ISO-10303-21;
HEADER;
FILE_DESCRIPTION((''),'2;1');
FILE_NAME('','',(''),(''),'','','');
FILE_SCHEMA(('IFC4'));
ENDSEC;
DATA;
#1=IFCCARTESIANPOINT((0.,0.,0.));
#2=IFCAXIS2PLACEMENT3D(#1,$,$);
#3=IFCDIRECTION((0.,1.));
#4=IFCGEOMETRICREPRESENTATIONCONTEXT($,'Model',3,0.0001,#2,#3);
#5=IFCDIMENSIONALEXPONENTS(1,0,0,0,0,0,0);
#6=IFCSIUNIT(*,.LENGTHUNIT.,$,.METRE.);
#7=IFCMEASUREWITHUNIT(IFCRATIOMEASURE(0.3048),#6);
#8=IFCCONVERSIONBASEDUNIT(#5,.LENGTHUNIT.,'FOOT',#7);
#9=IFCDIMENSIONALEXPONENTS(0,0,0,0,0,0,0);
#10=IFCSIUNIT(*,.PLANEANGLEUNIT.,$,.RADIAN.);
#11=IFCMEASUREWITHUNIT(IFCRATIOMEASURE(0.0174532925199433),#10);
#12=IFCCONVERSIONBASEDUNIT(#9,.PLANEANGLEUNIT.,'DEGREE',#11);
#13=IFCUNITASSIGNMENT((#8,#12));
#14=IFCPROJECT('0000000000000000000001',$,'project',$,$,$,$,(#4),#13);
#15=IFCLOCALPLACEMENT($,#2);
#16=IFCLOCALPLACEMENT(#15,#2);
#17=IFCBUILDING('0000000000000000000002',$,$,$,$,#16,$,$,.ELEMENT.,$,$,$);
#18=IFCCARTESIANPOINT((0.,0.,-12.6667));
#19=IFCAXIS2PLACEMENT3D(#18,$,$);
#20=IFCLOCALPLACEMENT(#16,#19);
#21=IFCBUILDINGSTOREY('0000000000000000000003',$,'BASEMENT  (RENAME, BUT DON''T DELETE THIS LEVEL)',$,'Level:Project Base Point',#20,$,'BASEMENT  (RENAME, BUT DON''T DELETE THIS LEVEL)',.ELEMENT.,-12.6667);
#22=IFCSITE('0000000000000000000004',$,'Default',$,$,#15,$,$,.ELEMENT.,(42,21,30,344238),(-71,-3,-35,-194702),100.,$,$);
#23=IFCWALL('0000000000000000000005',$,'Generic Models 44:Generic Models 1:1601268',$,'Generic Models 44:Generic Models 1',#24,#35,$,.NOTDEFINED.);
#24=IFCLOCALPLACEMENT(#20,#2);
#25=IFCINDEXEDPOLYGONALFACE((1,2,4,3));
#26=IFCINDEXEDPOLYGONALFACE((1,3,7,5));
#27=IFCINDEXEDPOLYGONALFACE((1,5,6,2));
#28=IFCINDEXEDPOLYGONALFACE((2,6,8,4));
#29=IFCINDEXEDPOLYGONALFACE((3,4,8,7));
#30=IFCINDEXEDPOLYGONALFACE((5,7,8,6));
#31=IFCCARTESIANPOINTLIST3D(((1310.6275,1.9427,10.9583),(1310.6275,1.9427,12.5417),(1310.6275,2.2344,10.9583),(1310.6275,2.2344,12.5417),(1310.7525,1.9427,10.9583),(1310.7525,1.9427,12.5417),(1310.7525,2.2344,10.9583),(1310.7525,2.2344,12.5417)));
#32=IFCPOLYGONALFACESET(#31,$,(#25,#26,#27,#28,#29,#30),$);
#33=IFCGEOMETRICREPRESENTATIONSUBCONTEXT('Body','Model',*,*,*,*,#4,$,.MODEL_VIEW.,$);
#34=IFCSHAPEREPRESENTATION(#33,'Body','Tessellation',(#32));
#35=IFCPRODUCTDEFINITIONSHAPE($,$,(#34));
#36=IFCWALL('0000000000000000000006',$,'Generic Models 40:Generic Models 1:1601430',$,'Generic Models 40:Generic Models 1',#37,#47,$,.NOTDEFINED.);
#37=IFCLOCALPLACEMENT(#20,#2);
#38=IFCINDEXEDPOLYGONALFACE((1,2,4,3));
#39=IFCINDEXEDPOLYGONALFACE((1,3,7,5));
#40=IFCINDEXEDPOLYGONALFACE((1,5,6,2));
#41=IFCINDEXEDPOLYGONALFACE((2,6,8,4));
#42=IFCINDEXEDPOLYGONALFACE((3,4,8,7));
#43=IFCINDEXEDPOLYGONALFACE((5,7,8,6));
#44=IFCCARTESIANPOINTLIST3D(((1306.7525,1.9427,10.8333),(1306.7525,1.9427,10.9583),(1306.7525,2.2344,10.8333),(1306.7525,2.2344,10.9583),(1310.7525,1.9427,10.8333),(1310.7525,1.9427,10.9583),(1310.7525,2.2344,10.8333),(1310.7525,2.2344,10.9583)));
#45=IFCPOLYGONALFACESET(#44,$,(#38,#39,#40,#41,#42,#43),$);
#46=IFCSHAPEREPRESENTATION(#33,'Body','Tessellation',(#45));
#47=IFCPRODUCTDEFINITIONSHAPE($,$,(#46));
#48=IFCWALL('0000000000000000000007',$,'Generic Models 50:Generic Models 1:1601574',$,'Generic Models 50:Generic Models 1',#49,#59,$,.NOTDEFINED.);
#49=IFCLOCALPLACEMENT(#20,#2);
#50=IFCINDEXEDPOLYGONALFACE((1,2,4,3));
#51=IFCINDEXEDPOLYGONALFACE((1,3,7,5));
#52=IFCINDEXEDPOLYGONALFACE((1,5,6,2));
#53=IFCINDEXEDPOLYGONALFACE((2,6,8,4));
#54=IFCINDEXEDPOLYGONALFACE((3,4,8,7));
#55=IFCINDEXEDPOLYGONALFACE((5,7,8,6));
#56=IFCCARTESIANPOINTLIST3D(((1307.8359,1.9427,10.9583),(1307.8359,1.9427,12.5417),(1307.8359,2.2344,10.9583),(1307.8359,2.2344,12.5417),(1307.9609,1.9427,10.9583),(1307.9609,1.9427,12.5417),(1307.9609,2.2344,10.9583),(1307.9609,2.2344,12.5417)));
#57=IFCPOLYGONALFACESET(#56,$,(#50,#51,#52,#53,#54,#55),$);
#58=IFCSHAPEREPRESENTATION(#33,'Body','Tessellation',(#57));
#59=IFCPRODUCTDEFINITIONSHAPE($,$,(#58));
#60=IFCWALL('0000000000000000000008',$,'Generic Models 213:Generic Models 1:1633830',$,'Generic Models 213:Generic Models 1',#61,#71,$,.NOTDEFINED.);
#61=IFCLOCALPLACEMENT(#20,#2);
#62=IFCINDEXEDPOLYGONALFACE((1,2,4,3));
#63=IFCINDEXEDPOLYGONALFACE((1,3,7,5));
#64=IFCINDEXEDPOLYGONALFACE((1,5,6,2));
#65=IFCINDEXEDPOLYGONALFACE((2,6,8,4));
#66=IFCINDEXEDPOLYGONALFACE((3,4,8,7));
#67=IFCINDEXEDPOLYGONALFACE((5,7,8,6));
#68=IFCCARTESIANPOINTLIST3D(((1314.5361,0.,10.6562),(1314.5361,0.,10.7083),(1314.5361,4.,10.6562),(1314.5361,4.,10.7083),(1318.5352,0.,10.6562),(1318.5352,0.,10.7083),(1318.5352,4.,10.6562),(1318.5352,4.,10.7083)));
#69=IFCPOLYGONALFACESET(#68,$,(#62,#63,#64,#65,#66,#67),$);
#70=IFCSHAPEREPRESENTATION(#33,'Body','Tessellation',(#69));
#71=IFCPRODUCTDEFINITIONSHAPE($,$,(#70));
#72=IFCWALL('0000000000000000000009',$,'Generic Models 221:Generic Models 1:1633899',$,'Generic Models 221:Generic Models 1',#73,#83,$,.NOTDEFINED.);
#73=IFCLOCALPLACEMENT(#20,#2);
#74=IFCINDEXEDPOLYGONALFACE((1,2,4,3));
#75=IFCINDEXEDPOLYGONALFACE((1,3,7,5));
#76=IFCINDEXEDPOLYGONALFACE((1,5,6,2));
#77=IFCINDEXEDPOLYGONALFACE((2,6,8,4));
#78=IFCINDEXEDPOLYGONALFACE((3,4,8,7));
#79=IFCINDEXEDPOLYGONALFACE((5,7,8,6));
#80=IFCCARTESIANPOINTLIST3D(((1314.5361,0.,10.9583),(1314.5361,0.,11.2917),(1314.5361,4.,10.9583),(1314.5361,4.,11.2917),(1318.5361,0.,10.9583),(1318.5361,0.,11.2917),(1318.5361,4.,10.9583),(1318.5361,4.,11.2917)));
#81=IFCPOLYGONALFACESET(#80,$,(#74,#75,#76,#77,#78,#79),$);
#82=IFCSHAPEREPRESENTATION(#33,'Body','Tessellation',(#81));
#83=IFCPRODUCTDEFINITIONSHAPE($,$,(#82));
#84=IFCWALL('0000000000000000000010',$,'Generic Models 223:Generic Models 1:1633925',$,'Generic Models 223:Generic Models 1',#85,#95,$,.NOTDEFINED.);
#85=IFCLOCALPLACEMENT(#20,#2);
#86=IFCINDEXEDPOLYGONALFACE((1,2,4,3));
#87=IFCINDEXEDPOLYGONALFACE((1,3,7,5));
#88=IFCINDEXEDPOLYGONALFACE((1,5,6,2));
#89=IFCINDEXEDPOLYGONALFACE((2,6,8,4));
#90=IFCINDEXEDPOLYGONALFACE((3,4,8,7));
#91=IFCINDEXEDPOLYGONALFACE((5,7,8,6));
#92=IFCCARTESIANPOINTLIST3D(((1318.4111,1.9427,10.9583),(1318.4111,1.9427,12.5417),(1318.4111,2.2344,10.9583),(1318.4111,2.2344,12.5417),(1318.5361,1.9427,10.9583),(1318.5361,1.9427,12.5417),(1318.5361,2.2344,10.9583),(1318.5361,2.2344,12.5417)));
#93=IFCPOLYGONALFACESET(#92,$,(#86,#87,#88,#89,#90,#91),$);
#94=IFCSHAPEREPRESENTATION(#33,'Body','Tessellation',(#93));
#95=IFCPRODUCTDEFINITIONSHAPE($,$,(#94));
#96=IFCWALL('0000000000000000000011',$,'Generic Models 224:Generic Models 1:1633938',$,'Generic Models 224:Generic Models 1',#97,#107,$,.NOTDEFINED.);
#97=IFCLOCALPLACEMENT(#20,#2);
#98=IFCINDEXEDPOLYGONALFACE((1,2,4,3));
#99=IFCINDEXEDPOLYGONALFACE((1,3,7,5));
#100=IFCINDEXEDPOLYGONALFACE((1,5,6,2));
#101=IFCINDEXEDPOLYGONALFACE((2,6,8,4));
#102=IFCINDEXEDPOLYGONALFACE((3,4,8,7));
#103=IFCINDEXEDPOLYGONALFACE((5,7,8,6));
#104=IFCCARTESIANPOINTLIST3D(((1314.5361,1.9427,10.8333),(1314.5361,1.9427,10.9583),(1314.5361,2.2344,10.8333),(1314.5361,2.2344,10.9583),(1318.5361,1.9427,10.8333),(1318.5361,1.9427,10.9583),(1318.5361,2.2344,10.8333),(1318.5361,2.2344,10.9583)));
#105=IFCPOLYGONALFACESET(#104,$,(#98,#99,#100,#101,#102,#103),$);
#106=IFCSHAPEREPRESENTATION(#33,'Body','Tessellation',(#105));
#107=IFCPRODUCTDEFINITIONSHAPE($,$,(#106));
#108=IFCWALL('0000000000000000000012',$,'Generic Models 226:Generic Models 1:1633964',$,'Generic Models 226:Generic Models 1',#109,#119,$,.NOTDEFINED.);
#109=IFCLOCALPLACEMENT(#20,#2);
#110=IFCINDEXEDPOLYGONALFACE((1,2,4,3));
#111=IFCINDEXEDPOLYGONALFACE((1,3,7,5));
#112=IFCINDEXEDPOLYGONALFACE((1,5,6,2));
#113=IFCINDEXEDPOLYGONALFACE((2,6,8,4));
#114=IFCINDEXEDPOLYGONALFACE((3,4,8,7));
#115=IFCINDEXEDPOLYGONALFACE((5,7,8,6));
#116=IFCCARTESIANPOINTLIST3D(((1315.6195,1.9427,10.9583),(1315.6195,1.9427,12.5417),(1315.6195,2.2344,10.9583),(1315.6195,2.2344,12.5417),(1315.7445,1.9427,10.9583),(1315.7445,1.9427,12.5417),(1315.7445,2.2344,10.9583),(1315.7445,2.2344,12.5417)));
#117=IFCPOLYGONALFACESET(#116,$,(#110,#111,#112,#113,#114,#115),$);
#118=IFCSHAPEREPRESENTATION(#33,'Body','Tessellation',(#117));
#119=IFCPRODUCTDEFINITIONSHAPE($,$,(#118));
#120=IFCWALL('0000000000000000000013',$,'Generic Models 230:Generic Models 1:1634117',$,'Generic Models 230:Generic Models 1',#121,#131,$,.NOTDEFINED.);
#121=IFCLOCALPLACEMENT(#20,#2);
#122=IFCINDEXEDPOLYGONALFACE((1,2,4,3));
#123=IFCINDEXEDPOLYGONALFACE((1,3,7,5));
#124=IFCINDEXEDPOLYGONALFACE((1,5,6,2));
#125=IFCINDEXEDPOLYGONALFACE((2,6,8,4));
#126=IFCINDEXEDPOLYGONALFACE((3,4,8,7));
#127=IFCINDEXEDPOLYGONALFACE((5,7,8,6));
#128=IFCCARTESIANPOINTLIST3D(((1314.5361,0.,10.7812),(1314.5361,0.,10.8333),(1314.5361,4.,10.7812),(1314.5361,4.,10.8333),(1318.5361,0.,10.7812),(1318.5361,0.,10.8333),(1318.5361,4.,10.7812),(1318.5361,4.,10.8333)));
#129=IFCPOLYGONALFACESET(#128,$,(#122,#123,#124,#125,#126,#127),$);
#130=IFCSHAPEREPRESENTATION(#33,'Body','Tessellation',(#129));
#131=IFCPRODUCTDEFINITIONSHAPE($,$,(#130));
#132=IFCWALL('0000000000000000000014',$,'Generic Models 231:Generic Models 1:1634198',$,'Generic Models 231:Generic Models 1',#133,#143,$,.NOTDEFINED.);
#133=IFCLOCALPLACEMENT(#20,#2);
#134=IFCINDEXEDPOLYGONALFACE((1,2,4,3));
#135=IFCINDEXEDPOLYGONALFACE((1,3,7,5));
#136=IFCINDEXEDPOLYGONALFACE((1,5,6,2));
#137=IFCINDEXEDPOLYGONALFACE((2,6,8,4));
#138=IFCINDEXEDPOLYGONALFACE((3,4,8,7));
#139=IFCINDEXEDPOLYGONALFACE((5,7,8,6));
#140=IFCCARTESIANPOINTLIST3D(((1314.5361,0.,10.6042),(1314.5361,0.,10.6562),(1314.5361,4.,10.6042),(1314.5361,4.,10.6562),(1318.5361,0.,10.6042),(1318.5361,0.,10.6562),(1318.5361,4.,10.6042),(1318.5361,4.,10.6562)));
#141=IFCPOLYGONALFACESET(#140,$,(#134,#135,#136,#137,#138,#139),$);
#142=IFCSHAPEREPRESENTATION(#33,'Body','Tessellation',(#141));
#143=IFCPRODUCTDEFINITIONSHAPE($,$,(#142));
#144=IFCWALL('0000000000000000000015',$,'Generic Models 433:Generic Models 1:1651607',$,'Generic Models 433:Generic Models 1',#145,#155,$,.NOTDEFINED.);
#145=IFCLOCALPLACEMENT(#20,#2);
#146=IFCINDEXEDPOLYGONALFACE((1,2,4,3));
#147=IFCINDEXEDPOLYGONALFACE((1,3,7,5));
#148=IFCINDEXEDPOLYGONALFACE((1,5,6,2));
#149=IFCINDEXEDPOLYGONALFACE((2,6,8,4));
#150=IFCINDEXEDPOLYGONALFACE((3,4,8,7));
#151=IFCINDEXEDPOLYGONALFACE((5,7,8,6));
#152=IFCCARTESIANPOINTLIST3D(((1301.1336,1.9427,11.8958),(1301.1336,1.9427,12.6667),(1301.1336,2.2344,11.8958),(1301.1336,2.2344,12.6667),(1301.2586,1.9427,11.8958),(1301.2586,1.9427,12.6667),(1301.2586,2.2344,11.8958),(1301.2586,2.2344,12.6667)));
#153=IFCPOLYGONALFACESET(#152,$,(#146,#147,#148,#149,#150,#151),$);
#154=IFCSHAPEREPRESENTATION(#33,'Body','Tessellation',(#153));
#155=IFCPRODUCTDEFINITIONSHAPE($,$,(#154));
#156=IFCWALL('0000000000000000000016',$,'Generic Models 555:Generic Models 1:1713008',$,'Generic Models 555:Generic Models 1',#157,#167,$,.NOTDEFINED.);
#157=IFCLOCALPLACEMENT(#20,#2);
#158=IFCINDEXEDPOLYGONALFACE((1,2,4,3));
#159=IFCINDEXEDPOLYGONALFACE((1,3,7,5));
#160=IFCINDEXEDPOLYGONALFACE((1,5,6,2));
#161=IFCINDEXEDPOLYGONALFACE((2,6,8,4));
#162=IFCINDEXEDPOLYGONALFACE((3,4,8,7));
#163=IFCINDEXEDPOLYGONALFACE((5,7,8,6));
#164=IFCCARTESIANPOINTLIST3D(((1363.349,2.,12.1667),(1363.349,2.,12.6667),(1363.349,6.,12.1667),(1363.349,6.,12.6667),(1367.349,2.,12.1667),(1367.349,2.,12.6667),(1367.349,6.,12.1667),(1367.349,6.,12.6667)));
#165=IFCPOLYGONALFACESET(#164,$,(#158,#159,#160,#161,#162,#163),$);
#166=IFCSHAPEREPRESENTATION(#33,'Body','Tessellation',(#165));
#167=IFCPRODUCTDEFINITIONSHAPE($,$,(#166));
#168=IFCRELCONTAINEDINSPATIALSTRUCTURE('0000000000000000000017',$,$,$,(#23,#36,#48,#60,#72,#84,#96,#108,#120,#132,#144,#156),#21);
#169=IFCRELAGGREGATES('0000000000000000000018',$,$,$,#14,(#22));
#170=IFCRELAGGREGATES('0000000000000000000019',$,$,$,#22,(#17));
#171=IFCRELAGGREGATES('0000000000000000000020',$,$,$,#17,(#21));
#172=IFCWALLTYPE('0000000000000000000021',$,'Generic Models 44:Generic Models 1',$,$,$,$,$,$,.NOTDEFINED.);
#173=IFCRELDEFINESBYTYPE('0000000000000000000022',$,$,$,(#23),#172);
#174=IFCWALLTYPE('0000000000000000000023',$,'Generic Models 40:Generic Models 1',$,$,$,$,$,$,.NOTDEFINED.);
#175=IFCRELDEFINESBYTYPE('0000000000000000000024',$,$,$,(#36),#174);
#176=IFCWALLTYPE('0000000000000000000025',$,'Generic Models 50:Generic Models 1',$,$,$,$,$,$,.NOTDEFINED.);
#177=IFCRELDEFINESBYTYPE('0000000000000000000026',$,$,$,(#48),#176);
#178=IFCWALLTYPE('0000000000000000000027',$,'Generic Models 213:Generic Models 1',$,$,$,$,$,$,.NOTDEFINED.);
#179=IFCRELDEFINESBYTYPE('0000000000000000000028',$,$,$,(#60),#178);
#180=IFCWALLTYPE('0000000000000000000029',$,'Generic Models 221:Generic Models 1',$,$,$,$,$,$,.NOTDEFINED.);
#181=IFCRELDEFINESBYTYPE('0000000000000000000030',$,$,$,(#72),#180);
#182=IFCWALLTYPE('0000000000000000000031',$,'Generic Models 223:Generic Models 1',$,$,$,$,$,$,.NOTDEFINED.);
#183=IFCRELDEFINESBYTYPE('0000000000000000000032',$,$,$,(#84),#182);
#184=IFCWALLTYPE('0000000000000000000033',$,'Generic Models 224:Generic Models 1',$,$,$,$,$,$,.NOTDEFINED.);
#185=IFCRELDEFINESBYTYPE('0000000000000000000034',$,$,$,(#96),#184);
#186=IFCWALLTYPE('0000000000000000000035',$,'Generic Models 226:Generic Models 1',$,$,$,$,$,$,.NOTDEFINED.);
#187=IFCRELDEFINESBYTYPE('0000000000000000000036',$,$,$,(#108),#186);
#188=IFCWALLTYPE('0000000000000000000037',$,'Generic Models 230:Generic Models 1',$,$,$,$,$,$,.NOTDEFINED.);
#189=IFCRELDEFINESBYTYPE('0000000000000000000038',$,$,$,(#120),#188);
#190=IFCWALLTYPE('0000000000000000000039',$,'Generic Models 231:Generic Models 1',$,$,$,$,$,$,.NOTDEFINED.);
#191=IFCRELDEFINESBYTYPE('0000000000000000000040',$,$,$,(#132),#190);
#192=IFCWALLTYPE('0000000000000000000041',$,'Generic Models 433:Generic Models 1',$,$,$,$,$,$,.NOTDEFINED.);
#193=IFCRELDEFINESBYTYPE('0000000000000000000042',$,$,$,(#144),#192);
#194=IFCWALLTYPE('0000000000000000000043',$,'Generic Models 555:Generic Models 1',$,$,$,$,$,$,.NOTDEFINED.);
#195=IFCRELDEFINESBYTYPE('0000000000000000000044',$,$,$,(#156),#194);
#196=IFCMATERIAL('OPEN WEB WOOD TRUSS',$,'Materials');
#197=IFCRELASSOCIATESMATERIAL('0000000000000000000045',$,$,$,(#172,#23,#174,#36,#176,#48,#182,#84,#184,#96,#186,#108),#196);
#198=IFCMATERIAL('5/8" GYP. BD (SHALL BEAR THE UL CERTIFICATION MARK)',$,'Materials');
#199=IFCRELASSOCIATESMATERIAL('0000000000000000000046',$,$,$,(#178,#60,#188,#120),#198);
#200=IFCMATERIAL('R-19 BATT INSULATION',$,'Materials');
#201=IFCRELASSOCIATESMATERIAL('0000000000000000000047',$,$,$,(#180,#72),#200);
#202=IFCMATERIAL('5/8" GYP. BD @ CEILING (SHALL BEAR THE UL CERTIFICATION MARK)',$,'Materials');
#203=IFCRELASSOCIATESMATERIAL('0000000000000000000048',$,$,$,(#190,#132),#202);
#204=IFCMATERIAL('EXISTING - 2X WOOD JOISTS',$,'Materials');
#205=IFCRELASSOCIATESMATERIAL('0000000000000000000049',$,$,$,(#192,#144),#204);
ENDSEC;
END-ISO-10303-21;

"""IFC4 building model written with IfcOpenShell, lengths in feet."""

from ifc_helpers import new_model, entity, si_unit, converted_unit, direction, frame, frame_2d, origin, origin_2d_with_axis, place, context, subcontext, project, spatial, rectangle, extrude, material, type_object, element, save


model = new_model("IFC4")

# Units and contexts
model_context = context("Model", 3, precision=0.0001, world=origin(), true_north=direction((0.0, 1.0)))
body_context = subcontext(model_context, "Body", "Model", "MODEL_VIEW")
ifc_project = project(units=[converted_unit("LENGTHUNIT", "FOOT", entity("IfcRatioMeasure", 0.3048), si_unit("LENGTHUNIT", "METRE"), dimensions=[1, 0, 0, 0, 0, 0, 0]), converted_unit("PLANEANGLEUNIT", "DEGREE", entity("IfcRatioMeasure", 0.0174532925199433), si_unit("PLANEANGLEUNIT", "RADIAN"), dimensions=[0, 0, 0, 0, 0, 0, 0])], contexts=[model_context])

# Site, building, storey
site_placement = place(None, origin())
site = spatial("IfcSite", under=ifc_project, at=site_placement, Name="Default", CompositionType="ELEMENT", RefLatitude=(42, 21, 30, 344238), RefLongitude=(-71, -3, -35, -194702), RefElevation=100.0)
building_placement = place(site_placement, origin())
building = spatial("IfcBuilding", under=site, at=building_placement, CompositionType="ELEMENT")
storey_placement = place(building_placement, frame((0.0, 0.0, -12.6667)))
storey = spatial("IfcBuildingStorey", under=building, at=storey_placement, Name="BASEMENT  (RENAME, BUT DON'T DELETE THIS LEVEL)", ObjectType="Level:Project Base Point", LongName="BASEMENT  (RENAME, BUT DON'T DELETE THIS LEVEL)", CompositionType="ELEMENT", Elevation=-12.6667)

# Walls
ifc_material_1 = material(Name="OPEN WEB WOOD TRUSS", Category="Materials")
wall_type_1 = type_object("IfcWallType", Name="Generic Models 44:Generic Models 1", PredefinedType="NOTDEFINED", material=ifc_material_1)
wall_1_placement = place(storey_placement, frame((1310.6275, 1.9427, 10.9583), z_axis=(0.0, 0.0, 1.0), x_axis=(0.0, 1.0, 0.0)))
element("IfcWall", 1, at=wall_1_placement, inside=storey, type_object=wall_type_1, material=ifc_material_1, Name="Generic Models 44:Generic Models 1:1601268", ObjectType="Generic Models 44:Generic Models 1", PredefinedType="NOTDEFINED", context=body_context, shape_type="SweptSolid", body=[
    extrude(rectangle(XDim=0.2917, YDim=0.125, at=frame_2d((0.0, 0.0), x_axis=(1.0, 0.0))), frame((0.1458, -0.0625, 0.0)), (0.0, 0.0, 1.0), 1.5833),
])
wall_type_2 = type_object("IfcWallType", Name="Generic Models 40:Generic Models 1", PredefinedType="NOTDEFINED", material=ifc_material_1)
wall_2_placement = place(storey_placement, frame((1306.7525, 1.9427, 10.8333)))
element("IfcWall", 2, at=wall_2_placement, inside=storey, type_object=wall_type_2, material=ifc_material_1, Name="Generic Models 40:Generic Models 1:1601430", ObjectType="Generic Models 40:Generic Models 1", PredefinedType="NOTDEFINED", context=body_context, shape_type="SweptSolid", body=[
    extrude(rectangle(XDim=0.2917, YDim=4.0, at=frame_2d((0.0, 0.0), x_axis=(1.0, 0.0))), frame((2.0, 0.1458, 0.0), z_axis=(0.0, 0.0, 1.0), x_axis=(0.0, 1.0, 0.0)), (0.0, 0.0, 1.0), 0.125),
])
wall_type_3 = type_object("IfcWallType", Name="Generic Models 50:Generic Models 1", PredefinedType="NOTDEFINED", material=ifc_material_1)
wall_3_placement = place(storey_placement, frame((1307.8359, 1.9427, 10.9583), z_axis=(0.0, 0.0, 1.0), x_axis=(0.0, 1.0, 0.0)))
element("IfcWall", 3, at=wall_3_placement, inside=storey, type_object=wall_type_3, material=ifc_material_1, Name="Generic Models 50:Generic Models 1:1601574", ObjectType="Generic Models 50:Generic Models 1", PredefinedType="NOTDEFINED", context=body_context, shape_type="SweptSolid", body=[
    extrude(rectangle(XDim=0.2917, YDim=0.125, at=frame_2d((0.0, 0.0), x_axis=(1.0, 0.0))), frame((0.1458, -0.0625, 0.0)), (0.0, 0.0, 1.0), 1.5833),
])
ifc_material_2 = material(Name="5/8\" GYP. BD (SHALL BEAR THE UL CERTIFICATION MARK)", Category="Materials")
wall_type_4 = type_object("IfcWallType", Name="Generic Models 213:Generic Models 1", PredefinedType="NOTDEFINED", material=ifc_material_2)
wall_4_placement = place(storey_placement, frame((1314.5361, 0.0, 10.6562), z_axis=(0.0, 0.0, 1.0), x_axis=(0.0, 1.0, 0.0)))
element("IfcWall", 4, at=wall_4_placement, inside=storey, type_object=wall_type_4, material=ifc_material_2, Name="Generic Models 213:Generic Models 1:1633830", ObjectType="Generic Models 213:Generic Models 1", PredefinedType="NOTDEFINED", context=body_context, shape_type="SweptSolid", body=[
    extrude(rectangle(XDim=4.0, YDim=3.999, at=origin_2d_with_axis()), frame((2.0, -1.9995, 0.0)), (0.0, 0.0, 1.0), 0.0521),
])
ifc_material_3 = material(Name="R-19 BATT INSULATION", Category="Materials")
wall_type_5 = type_object("IfcWallType", Name="Generic Models 221:Generic Models 1", PredefinedType="NOTDEFINED", material=ifc_material_3)
wall_5_placement = place(storey_placement, frame((1314.5361, 0.0, 10.9583), z_axis=(0.0, 0.0, 1.0), x_axis=(0.0, 1.0, 0.0)))
element("IfcWall", 5, at=wall_5_placement, inside=storey, type_object=wall_type_5, material=ifc_material_3, Name="Generic Models 221:Generic Models 1:1633899", ObjectType="Generic Models 221:Generic Models 1", PredefinedType="NOTDEFINED", context=body_context, shape_type="SweptSolid", body=[
    extrude(rectangle(XDim=4.0, YDim=4.0, at=frame_2d((0.0, 0.0), x_axis=(1.0, 0.0))), frame((2.0, -2.0, 0.0)), (0.0, 0.0, 1.0), 0.3333),
])
wall_type_6 = type_object("IfcWallType", Name="Generic Models 223:Generic Models 1", PredefinedType="NOTDEFINED", material=ifc_material_1)
wall_6_placement = place(storey_placement, frame((1318.4111, 1.9427, 10.9583), z_axis=(0.0, 0.0, 1.0), x_axis=(0.0, 1.0, 0.0)))
element("IfcWall", 6, at=wall_6_placement, inside=storey, type_object=wall_type_6, material=ifc_material_1, Name="Generic Models 223:Generic Models 1:1633925", ObjectType="Generic Models 223:Generic Models 1", PredefinedType="NOTDEFINED", context=body_context, shape_type="SweptSolid", body=[
    extrude(rectangle(XDim=0.2917, YDim=0.125, at=frame_2d((0.0, 0.0), x_axis=(1.0, 0.0))), frame((0.1458, -0.0625, 0.0)), (0.0, 0.0, 1.0), 1.5833),
])
wall_type_7 = type_object("IfcWallType", Name="Generic Models 224:Generic Models 1", PredefinedType="NOTDEFINED", material=ifc_material_1)
wall_7_placement = place(storey_placement, frame((1314.5361, 1.9427, 10.8333)))
element("IfcWall", 7, at=wall_7_placement, inside=storey, type_object=wall_type_7, material=ifc_material_1, Name="Generic Models 224:Generic Models 1:1633938", ObjectType="Generic Models 224:Generic Models 1", PredefinedType="NOTDEFINED", context=body_context, shape_type="SweptSolid", body=[
    extrude(rectangle(XDim=0.2917, YDim=4.0, at=frame_2d((0.0, 0.0), x_axis=(1.0, 0.0))), frame((2.0, 0.1458, 0.0), z_axis=(0.0, 0.0, 1.0), x_axis=(0.0, 1.0, 0.0)), (0.0, 0.0, 1.0), 0.125),
])
wall_type_8 = type_object("IfcWallType", Name="Generic Models 226:Generic Models 1", PredefinedType="NOTDEFINED", material=ifc_material_1)
wall_8_placement = place(storey_placement, frame((1315.6195, 1.9427, 10.9583), z_axis=(0.0, 0.0, 1.0), x_axis=(0.0, 1.0, 0.0)))
element("IfcWall", 8, at=wall_8_placement, inside=storey, type_object=wall_type_8, material=ifc_material_1, Name="Generic Models 226:Generic Models 1:1633964", ObjectType="Generic Models 226:Generic Models 1", PredefinedType="NOTDEFINED", context=body_context, shape_type="SweptSolid", body=[
    extrude(rectangle(XDim=0.2917, YDim=0.125, at=frame_2d((0.0, 0.0), x_axis=(1.0, 0.0))), frame((0.1458, -0.0625, 0.0)), (0.0, 0.0, 1.0), 1.5833),
])
wall_type_9 = type_object("IfcWallType", Name="Generic Models 230:Generic Models 1", PredefinedType="NOTDEFINED", material=ifc_material_2)
wall_9_placement = place(storey_placement, frame((1314.5361, 0.0, 10.7812), z_axis=(0.0, 0.0, 1.0), x_axis=(0.0, 1.0, 0.0)))
element("IfcWall", 9, at=wall_9_placement, inside=storey, type_object=wall_type_9, material=ifc_material_2, Name="Generic Models 230:Generic Models 1:1634117", ObjectType="Generic Models 230:Generic Models 1", PredefinedType="NOTDEFINED", context=body_context, shape_type="SweptSolid", body=[
    extrude(rectangle(XDim=4.0, YDim=4.0, at=origin_2d_with_axis()), frame((2.0, -2.0, 0.0)), (0.0, 0.0, 1.0), 0.0521),
])
ifc_material_4 = material(Name="5/8\" GYP. BD @ CEILING (SHALL BEAR THE UL CERTIFICATION MARK)", Category="Materials")
wall_type_10 = type_object("IfcWallType", Name="Generic Models 231:Generic Models 1", PredefinedType="NOTDEFINED", material=ifc_material_4)
wall_10_placement = place(storey_placement, frame((1314.5361, 0.0, 10.6042), z_axis=(0.0, 0.0, 1.0), x_axis=(0.0, 1.0, 0.0)))
element("IfcWall", 10, at=wall_10_placement, inside=storey, type_object=wall_type_10, material=ifc_material_4, Name="Generic Models 231:Generic Models 1:1634198", ObjectType="Generic Models 231:Generic Models 1", PredefinedType="NOTDEFINED", context=body_context, shape_type="SweptSolid", body=[
    extrude(rectangle(XDim=4.0, YDim=4.0, at=origin_2d_with_axis()), frame((2.0, -2.0, 0.0)), (0.0, 0.0, 1.0), 0.0521),
])
ifc_material_5 = material(Name="EXISTING - 2X WOOD JOISTS", Category="Materials")
wall_type_11 = type_object("IfcWallType", Name="Generic Models 433:Generic Models 1", PredefinedType="NOTDEFINED", material=ifc_material_5)
wall_11_placement = place(storey_placement, frame((1301.1336, 1.9427, 11.8958), z_axis=(0.0, 0.0, 1.0), x_axis=(0.0, 1.0, 0.0)))
element("IfcWall", 11, at=wall_11_placement, inside=storey, type_object=wall_type_11, material=ifc_material_5, Name="Generic Models 433:Generic Models 1:1651607", ObjectType="Generic Models 433:Generic Models 1", PredefinedType="NOTDEFINED", context=body_context, shape_type="SweptSolid", body=[
    extrude(rectangle(XDim=0.2917, YDim=0.125, at=frame_2d((0.0, 0.0), x_axis=(1.0, 0.0))), frame((0.1458, -0.0625, 0.0)), (0.0, 0.0, 1.0), 0.7708),
])
wall_type_12 = type_object("IfcWallType", Name="Generic Models 555:Generic Models 1", PredefinedType="NOTDEFINED")
wall_12_placement = place(storey_placement, frame((1363.349, 2.0, 12.1667), z_axis=(0.0, 0.0, 1.0), x_axis=(0.0, 1.0, 0.0)))
element("IfcWall", 12, at=wall_12_placement, inside=storey, type_object=wall_type_12, Name="Generic Models 555:Generic Models 1:1713008", ObjectType="Generic Models 555:Generic Models 1", PredefinedType="NOTDEFINED", context=body_context, shape_type="SweptSolid", body=[
    extrude(rectangle(XDim=4.0, YDim=4.0, at=origin_2d_with_axis()), frame((2.0, -2.0, 0.0)), (0.0, 0.0, 1.0), 0.5),
])

save(model, "model.ifc")
